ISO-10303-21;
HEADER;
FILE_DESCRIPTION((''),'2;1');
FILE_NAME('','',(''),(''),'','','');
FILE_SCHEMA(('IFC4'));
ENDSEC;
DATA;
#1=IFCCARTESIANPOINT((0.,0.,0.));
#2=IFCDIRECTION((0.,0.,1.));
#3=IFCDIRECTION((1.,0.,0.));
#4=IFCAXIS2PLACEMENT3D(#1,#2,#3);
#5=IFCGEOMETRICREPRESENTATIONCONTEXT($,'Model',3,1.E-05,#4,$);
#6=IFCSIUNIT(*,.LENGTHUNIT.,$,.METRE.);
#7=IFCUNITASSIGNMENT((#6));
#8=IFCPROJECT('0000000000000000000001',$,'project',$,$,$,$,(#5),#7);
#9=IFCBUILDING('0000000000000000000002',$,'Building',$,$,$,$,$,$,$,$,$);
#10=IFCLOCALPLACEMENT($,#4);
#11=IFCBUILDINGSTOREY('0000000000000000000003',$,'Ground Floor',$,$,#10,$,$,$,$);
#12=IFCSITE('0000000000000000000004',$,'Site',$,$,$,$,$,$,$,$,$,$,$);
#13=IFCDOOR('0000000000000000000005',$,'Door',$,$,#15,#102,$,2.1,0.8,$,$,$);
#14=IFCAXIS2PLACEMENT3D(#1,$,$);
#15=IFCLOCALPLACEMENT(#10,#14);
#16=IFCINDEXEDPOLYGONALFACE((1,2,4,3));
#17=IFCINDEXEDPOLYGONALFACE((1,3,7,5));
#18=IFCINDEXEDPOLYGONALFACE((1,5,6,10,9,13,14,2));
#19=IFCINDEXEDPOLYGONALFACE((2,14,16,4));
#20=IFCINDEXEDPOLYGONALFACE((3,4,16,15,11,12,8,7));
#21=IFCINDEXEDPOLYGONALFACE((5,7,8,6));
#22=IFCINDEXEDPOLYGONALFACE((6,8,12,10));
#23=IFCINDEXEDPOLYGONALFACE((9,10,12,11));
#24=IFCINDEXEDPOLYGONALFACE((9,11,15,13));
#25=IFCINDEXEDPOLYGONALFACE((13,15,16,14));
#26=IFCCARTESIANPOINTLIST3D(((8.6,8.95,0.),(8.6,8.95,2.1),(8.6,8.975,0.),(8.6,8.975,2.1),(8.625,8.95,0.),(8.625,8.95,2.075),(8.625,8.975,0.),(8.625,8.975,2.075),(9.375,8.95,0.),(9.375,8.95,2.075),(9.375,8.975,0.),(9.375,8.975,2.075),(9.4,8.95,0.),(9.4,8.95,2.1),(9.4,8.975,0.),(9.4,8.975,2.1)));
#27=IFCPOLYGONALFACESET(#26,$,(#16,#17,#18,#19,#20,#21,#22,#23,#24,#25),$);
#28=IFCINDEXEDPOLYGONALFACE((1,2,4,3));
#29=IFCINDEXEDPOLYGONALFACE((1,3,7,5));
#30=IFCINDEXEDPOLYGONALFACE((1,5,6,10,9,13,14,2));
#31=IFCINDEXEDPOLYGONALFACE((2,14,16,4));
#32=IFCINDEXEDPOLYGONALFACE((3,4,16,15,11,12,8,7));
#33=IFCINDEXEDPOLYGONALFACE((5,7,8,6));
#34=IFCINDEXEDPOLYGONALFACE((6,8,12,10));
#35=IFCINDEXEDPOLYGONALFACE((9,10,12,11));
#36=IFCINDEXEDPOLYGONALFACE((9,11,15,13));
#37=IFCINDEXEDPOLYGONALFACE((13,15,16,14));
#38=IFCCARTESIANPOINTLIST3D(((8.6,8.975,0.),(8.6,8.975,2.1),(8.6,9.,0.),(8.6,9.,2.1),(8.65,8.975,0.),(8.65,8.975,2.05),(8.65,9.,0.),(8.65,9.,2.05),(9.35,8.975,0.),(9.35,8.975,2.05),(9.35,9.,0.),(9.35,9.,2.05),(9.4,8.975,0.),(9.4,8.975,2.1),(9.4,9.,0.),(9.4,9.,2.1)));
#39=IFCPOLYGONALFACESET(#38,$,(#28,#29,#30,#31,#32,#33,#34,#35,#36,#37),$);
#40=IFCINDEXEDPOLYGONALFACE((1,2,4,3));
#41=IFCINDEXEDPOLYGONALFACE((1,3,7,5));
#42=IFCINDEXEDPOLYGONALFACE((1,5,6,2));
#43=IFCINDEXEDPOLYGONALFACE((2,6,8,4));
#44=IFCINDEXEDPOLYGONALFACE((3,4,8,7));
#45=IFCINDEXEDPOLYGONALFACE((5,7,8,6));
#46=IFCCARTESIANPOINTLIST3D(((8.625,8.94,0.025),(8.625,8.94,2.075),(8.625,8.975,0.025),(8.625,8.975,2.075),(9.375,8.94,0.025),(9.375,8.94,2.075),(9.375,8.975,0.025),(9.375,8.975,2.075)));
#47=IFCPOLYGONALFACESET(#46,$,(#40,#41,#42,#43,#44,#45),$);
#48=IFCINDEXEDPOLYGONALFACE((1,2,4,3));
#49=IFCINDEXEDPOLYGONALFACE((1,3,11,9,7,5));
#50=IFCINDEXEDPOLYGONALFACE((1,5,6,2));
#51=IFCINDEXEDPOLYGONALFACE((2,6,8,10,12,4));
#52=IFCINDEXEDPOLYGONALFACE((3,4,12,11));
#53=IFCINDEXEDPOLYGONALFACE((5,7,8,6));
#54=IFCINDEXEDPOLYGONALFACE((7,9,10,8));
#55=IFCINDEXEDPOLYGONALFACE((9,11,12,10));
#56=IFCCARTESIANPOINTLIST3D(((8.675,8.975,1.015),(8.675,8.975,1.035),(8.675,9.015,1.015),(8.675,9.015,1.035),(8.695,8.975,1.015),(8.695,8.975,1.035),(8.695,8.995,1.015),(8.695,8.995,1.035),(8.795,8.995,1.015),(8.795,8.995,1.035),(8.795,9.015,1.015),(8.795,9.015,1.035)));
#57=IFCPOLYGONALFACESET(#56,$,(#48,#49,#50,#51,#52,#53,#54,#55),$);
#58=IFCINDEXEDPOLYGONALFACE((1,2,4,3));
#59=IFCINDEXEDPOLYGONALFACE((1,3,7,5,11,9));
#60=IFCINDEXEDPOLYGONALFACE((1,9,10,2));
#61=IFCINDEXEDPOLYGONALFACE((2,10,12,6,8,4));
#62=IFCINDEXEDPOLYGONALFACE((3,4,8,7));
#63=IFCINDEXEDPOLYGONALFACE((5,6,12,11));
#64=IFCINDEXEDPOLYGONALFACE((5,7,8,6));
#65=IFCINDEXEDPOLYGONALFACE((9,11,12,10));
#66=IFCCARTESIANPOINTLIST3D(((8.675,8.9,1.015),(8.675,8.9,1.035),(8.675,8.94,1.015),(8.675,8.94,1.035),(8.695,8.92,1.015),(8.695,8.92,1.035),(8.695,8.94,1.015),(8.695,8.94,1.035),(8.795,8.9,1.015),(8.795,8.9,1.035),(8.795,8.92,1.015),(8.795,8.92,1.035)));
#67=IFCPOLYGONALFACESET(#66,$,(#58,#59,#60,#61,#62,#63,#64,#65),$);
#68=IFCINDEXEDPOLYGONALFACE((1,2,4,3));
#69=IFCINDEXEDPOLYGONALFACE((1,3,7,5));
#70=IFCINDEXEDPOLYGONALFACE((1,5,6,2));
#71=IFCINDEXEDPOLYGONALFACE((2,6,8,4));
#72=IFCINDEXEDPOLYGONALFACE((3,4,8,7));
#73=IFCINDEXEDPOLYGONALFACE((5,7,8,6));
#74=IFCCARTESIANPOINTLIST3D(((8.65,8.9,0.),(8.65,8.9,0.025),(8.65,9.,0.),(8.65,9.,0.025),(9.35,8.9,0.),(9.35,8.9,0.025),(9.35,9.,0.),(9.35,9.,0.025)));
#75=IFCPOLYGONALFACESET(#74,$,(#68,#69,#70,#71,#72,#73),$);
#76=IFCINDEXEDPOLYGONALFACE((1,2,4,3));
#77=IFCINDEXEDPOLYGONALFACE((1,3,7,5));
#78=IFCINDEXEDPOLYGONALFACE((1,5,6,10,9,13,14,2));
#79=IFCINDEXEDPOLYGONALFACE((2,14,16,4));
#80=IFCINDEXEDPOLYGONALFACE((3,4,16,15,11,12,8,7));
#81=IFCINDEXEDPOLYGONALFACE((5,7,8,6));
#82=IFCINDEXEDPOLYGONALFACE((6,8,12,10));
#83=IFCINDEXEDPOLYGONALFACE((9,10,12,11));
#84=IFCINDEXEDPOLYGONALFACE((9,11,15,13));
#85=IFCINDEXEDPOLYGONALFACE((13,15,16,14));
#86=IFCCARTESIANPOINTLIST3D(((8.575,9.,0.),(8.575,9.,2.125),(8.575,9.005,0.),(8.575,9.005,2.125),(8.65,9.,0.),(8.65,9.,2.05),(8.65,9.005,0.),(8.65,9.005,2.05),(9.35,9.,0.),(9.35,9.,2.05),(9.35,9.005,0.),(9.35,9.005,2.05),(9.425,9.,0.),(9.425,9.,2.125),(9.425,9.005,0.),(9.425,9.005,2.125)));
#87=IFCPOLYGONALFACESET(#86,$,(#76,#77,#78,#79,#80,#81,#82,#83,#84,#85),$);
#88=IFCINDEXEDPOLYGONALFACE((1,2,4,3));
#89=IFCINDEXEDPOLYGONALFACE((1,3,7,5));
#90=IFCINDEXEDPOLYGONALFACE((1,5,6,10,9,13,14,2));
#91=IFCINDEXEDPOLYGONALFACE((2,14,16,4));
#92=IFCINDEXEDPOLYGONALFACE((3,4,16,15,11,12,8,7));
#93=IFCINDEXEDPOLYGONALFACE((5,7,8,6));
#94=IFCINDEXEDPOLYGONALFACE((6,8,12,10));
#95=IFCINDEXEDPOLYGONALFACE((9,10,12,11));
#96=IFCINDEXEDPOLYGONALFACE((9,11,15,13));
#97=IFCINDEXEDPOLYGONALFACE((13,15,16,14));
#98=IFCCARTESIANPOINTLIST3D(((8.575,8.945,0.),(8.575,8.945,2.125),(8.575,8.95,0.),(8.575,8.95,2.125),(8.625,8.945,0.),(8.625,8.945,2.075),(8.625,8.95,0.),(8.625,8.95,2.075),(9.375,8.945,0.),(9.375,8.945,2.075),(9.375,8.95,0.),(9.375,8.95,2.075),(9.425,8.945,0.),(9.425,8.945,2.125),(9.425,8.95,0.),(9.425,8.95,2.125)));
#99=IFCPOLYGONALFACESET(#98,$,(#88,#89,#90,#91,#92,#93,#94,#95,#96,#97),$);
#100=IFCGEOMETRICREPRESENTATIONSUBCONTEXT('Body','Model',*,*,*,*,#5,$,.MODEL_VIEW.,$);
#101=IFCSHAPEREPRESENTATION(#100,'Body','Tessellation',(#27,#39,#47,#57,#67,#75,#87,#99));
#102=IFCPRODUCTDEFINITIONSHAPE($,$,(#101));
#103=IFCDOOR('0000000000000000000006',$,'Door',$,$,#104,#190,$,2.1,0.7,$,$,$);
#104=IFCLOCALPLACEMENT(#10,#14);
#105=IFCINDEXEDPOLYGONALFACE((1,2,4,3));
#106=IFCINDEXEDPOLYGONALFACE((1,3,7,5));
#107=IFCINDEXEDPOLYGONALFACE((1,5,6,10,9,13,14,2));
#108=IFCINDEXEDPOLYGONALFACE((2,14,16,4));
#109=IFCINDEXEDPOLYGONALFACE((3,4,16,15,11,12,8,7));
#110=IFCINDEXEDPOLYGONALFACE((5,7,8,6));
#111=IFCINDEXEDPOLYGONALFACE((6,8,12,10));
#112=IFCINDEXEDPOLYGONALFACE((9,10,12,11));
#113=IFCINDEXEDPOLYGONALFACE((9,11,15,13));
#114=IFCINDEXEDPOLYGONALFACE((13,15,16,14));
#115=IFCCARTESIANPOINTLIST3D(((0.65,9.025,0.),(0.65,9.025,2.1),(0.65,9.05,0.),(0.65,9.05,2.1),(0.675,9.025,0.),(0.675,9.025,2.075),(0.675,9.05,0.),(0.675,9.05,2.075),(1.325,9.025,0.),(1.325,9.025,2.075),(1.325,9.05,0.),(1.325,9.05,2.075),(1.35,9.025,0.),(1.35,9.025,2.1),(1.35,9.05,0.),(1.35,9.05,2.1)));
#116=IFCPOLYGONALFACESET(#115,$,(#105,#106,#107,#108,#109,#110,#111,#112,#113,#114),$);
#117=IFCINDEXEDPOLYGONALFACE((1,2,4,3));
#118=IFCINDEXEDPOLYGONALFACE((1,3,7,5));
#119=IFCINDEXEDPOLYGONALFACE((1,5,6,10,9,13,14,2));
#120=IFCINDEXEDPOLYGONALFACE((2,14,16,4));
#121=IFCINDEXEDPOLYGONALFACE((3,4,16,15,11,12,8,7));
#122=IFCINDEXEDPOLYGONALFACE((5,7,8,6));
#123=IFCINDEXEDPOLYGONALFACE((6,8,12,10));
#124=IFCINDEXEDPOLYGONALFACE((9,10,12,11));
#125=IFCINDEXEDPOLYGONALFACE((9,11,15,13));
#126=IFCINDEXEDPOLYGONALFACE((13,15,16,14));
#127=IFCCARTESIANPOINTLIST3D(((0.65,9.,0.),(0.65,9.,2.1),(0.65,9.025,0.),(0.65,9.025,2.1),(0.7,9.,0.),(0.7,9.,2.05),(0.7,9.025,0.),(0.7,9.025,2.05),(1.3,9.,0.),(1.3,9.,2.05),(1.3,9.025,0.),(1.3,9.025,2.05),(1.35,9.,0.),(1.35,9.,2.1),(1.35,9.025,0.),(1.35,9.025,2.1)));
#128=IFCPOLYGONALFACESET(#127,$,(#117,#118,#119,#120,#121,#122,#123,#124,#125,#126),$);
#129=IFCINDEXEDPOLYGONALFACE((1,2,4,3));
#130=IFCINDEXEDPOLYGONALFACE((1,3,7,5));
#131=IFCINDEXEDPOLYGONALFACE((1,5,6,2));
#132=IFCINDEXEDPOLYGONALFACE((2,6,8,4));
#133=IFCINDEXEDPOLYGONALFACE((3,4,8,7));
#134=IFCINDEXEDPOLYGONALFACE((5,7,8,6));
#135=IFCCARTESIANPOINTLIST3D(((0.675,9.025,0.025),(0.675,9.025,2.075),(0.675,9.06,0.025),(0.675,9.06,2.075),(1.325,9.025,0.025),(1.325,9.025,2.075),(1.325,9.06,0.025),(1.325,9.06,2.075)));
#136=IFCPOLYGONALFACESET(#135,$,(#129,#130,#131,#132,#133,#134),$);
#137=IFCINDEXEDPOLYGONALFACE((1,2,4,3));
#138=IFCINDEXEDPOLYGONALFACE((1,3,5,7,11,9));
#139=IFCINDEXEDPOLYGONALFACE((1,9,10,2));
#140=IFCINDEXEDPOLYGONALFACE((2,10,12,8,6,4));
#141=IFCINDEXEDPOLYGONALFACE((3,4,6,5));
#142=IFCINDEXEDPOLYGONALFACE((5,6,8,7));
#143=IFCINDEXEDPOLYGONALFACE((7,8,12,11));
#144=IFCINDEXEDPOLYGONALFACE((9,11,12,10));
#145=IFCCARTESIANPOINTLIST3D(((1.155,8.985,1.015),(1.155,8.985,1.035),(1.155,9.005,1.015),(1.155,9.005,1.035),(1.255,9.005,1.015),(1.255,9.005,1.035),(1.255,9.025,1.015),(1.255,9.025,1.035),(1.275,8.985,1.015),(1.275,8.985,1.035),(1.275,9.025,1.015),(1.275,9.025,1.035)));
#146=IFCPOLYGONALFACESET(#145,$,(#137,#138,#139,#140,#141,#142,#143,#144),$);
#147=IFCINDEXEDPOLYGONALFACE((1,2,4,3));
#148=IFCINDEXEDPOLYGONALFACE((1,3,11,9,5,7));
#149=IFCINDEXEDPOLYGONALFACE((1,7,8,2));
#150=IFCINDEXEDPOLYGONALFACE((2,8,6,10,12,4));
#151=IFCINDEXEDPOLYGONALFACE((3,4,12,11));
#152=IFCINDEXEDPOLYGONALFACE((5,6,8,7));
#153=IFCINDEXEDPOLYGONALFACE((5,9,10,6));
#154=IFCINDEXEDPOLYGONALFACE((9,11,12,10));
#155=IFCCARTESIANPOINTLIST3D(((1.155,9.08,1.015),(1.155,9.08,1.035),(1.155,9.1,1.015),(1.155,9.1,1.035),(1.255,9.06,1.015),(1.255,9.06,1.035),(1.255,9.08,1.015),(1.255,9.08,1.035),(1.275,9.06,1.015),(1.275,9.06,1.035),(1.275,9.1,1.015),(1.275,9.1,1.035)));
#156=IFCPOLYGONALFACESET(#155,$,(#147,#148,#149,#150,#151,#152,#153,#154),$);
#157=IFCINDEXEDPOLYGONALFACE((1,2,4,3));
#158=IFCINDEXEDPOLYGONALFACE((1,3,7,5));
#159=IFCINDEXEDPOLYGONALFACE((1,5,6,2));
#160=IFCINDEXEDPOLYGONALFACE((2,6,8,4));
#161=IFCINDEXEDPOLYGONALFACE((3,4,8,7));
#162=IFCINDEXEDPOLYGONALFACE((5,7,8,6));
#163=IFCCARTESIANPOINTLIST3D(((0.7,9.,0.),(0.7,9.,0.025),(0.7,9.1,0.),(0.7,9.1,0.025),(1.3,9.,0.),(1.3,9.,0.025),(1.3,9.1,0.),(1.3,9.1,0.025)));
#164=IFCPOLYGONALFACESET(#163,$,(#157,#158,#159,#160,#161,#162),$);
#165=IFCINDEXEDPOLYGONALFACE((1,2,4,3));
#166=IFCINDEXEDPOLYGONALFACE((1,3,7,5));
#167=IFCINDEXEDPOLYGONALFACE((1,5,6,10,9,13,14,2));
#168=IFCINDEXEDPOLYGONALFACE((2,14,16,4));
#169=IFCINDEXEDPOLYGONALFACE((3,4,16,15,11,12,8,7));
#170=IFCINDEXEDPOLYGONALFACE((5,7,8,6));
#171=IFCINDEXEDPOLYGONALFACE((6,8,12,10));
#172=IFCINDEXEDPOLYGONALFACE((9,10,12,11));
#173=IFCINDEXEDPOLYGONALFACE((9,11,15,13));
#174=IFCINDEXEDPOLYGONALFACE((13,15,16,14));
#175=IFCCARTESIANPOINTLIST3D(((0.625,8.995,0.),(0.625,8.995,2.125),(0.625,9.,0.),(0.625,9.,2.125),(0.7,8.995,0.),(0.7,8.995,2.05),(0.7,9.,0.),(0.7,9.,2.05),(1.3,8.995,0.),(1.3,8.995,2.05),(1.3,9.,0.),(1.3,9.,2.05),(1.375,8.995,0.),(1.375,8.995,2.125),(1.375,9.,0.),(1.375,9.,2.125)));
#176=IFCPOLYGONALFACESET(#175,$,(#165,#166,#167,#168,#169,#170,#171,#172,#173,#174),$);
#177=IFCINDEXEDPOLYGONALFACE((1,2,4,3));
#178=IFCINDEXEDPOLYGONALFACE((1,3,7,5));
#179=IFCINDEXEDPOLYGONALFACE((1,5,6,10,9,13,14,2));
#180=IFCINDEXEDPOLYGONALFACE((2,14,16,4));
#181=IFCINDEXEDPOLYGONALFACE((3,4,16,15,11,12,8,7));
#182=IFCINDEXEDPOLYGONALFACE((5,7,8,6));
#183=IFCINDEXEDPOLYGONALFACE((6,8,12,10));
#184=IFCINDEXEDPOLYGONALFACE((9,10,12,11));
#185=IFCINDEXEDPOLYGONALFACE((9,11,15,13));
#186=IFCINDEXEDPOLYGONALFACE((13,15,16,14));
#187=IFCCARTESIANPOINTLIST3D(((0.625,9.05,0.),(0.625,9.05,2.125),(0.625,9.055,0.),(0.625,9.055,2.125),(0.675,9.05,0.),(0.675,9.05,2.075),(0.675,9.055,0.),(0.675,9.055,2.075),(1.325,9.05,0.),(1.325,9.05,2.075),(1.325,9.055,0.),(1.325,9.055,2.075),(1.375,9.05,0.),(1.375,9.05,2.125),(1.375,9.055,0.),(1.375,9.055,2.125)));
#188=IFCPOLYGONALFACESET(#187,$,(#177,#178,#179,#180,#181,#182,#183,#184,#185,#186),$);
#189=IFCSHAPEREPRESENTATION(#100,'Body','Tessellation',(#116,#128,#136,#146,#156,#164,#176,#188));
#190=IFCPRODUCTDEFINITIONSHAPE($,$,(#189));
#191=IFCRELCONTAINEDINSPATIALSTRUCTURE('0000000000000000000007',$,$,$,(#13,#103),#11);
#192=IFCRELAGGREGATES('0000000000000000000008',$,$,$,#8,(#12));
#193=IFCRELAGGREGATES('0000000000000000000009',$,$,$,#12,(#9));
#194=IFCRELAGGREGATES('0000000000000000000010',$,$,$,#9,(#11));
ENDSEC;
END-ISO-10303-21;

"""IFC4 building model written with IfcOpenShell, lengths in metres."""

from ifc_helpers import new_model, si_unit, frame, origin_with_axes, place, context, subcontext, project, spatial, line, indexed_curve, outline, extrude, element, save


model = new_model("IFC4")

# Units and contexts
model_context = context("Model", 3, precision=1e-05, world=origin_with_axes())
body_context = subcontext(model_context, "Body", "Model", "MODEL_VIEW")
ifc_project = project(units=[si_unit("LENGTHUNIT", "METRE")], contexts=[model_context])

# Site, building, storey
site = spatial("IfcSite", under=ifc_project, Name="Site")
building = spatial("IfcBuilding", under=site, Name="Building")
storey_placement = place(None, origin_with_axes())
storey = spatial("IfcBuildingStorey", under=building, at=storey_placement, Name="Ground Floor")

# Doors
door_1_placement = place(storey_placement, frame((9.4, 9.0, 0.0), z_axis=(0.0, 0.0, 1.0), x_axis=(-1.0, 0.0, 0.0)))
element("IfcDoor", 1, at=door_1_placement, inside=storey, Name="Door", OverallHeight=2.1, OverallWidth=0.8, context=body_context, shape_type="SweptSolid", body=[
    extrude(outline(indexed_curve([(0.0, 0.0), (0.0, 2.1), (0.8, 2.1), (0.8, 0.0), (0.775, 0.0), (0.775, 2.075), (0.025, 2.075), (0.025, 0.0)], segments=[line(1, 2, 3, 4, 5, 6, 7, 8, 1)])), frame((0.0, 0.025, 0.0), z_axis=(0.0, -1.0, 0.0), x_axis=(1.0, 0.0, 0.0)), (0.0, 0.0, -1.0), 0.025),
    extrude(outline(indexed_curve([(0.0, 0.0), (0.0, 2.1), (0.8, 2.1), (0.8, 0.0), (0.75, 0.0), (0.75, 2.05), (0.05, 2.05), (0.05, 0.0)], segments=[line(1, 2, 3, 4, 5, 6, 7, 8, 1)])), frame((0.0, 0.0, 0.0), z_axis=(0.0, -1.0, 0.0), x_axis=(1.0, 0.0, 0.0)), (0.0, 0.0, -1.0), 0.025),
    extrude(outline(indexed_curve([(0.0, 0.0), (0.75, 0.0), (0.75, 0.035), (0.0, 0.035)], segments=[line(1, 2, 3, 4, 1)])), frame((0.025, 0.025, 0.025), z_axis=(0.0, 0.0, 1.0), x_axis=(1.0, 0.0, 0.0)), (0.0, 0.0, 1.0), 2.05),
    extrude(outline(indexed_curve([(0.0, 0.0), (0.0, -0.04), (-0.12, -0.04), (-0.12, -0.02), (-0.02, -0.02), (-0.02, 0.0)], segments=[line(1, 2, 3, 4, 5, 6, 1)])), frame((0.725, 0.025, 1.015), z_axis=(0.0, 0.0, 1.0), x_axis=(1.0, 0.0, 0.0)), (0.0, 0.0, 1.0), 0.02),
    extrude(outline(indexed_curve([(0.0, 0.0), (0.0, 0.04), (-0.12, 0.04), (-0.12, 0.02), (-0.02, 0.02), (-0.02, 0.0)], segments=[line(1, 2, 3, 4, 5, 6, 1)])), frame((0.725, 0.06, 1.015), z_axis=(0.0, 0.0, 1.0), x_axis=(1.0, 0.0, 0.0)), (0.0, 0.0, 1.0), 0.02),
    extrude(outline(indexed_curve([(0.0, 0.0), (0.7, 0.0), (0.7, 0.1), (0.0, 0.1)], segments=[line(1, 2, 3, 4, 1)])), frame((0.05, 0.0, 0.0), z_axis=(0.0, 0.0, 1.0), x_axis=(1.0, 0.0, 0.0)), (0.0, 0.0, 1.0), 0.025),
    extrude(outline(indexed_curve([(0.0, 0.0), (0.0, 2.125), (0.85, 2.125), (0.85, 0.0), (0.775, 0.0), (0.775, 2.05), (0.075, 2.05), (0.075, 0.0)], segments=[line(1, 2, 3, 4, 5, 6, 7, 8, 1)])), frame((-0.025, -0.005, 0.0), z_axis=(0.0, -1.0, 0.0), x_axis=(1.0, 0.0, 0.0)), (0.0, 0.0, -1.0), 0.005),
    extrude(outline(indexed_curve([(0.0, 0.0), (0.0, 2.125), (0.85, 2.125), (0.85, 0.0), (0.8, 0.0), (0.8, 2.075), (0.05, 2.075), (0.05, 0.0)], segments=[line(1, 2, 3, 4, 5, 6, 7, 8, 1)])), frame((-0.025, 0.05, 0.0), z_axis=(0.0, -1.0, 0.0), x_axis=(1.0, 0.0, 0.0)), (0.0, 0.0, -1.0), 0.005),
])
door_2_placement = place(storey_placement, frame((0.65, 9.0, 0.0), z_axis=(0.0, 0.0, 1.0), x_axis=(1.0, 0.0, 0.0)))
element("IfcDoor", 2, at=door_2_placement, inside=storey, Name="Door", OverallHeight=2.1, OverallWidth=0.7, context=body_context, shape_type="SweptSolid", body=[
    extrude(outline(indexed_curve([(0.0, 0.0), (0.0, 2.1), (0.7, 2.1), (0.7, 0.0), (0.675, 0.0), (0.675, 2.075), (0.025, 2.075), (0.025, 0.0)], segments=[line(1, 2, 3, 4, 5, 6, 7, 8, 1)])), frame((0.0, 0.025, 0.0), z_axis=(0.0, -1.0, 0.0), x_axis=(1.0, 0.0, 0.0)), (0.0, 0.0, -1.0), 0.025),
    extrude(outline(indexed_curve([(0.0, 0.0), (0.0, 2.1), (0.7, 2.1), (0.7, 0.0), (0.65, 0.0), (0.65, 2.05), (0.05, 2.05), (0.05, 0.0)], segments=[line(1, 2, 3, 4, 5, 6, 7, 8, 1)])), frame((0.0, 0.0, 0.0), z_axis=(0.0, -1.0, 0.0), x_axis=(1.0, 0.0, 0.0)), (0.0, 0.0, -1.0), 0.025),
    extrude(outline(indexed_curve([(0.0, 0.0), (0.65, 0.0), (0.65, 0.035), (0.0, 0.035)], segments=[line(1, 2, 3, 4, 1)])), frame((0.025, 0.025, 0.025), z_axis=(0.0, 0.0, 1.0), x_axis=(1.0, 0.0, 0.0)), (0.0, 0.0, 1.0), 2.05),
    extrude(outline(indexed_curve([(0.0, 0.0), (0.0, -0.04), (-0.12, -0.04), (-0.12, -0.02), (-0.02, -0.02), (-0.02, 0.0)], segments=[line(1, 2, 3, 4, 5, 6, 1)])), frame((0.625, 0.025, 1.015), z_axis=(0.0, 0.0, 1.0), x_axis=(1.0, 0.0, 0.0)), (0.0, 0.0, 1.0), 0.02),
    extrude(outline(indexed_curve([(0.0, 0.0), (0.0, 0.04), (-0.12, 0.04), (-0.12, 0.02), (-0.02, 0.02), (-0.02, 0.0)], segments=[line(1, 2, 3, 4, 5, 6, 1)])), frame((0.625, 0.06, 1.015), z_axis=(0.0, 0.0, 1.0), x_axis=(1.0, 0.0, 0.0)), (0.0, 0.0, 1.0), 0.02),
    extrude(outline(indexed_curve([(0.0, 0.0), (0.6, 0.0), (0.6, 0.1), (0.0, 0.1)], segments=[line(1, 2, 3, 4, 1)])), frame((0.05, 0.0, 0.0), z_axis=(0.0, 0.0, 1.0), x_axis=(1.0, 0.0, 0.0)), (0.0, 0.0, 1.0), 0.025),
    extrude(outline(indexed_curve([(0.0, 0.0), (0.0, 2.125), (0.75, 2.125), (0.75, 0.0), (0.675, 0.0), (0.675, 2.05), (0.075, 2.05), (0.075, 0.0)], segments=[line(1, 2, 3, 4, 5, 6, 7, 8, 1)])), frame((-0.025, -0.005, 0.0), z_axis=(0.0, -1.0, 0.0), x_axis=(1.0, 0.0, 0.0)), (0.0, 0.0, -1.0), 0.005),
    extrude(outline(indexed_curve([(0.0, 0.0), (0.0, 2.125), (0.75, 2.125), (0.75, 0.0), (0.7, 0.0), (0.7, 2.075), (0.05, 2.075), (0.05, 0.0)], segments=[line(1, 2, 3, 4, 5, 6, 7, 8, 1)])), frame((-0.025, 0.05, 0.0), z_axis=(0.0, -1.0, 0.0), x_axis=(1.0, 0.0, 0.0)), (0.0, 0.0, -1.0), 0.005),
])

save(model, "model.ifc")
